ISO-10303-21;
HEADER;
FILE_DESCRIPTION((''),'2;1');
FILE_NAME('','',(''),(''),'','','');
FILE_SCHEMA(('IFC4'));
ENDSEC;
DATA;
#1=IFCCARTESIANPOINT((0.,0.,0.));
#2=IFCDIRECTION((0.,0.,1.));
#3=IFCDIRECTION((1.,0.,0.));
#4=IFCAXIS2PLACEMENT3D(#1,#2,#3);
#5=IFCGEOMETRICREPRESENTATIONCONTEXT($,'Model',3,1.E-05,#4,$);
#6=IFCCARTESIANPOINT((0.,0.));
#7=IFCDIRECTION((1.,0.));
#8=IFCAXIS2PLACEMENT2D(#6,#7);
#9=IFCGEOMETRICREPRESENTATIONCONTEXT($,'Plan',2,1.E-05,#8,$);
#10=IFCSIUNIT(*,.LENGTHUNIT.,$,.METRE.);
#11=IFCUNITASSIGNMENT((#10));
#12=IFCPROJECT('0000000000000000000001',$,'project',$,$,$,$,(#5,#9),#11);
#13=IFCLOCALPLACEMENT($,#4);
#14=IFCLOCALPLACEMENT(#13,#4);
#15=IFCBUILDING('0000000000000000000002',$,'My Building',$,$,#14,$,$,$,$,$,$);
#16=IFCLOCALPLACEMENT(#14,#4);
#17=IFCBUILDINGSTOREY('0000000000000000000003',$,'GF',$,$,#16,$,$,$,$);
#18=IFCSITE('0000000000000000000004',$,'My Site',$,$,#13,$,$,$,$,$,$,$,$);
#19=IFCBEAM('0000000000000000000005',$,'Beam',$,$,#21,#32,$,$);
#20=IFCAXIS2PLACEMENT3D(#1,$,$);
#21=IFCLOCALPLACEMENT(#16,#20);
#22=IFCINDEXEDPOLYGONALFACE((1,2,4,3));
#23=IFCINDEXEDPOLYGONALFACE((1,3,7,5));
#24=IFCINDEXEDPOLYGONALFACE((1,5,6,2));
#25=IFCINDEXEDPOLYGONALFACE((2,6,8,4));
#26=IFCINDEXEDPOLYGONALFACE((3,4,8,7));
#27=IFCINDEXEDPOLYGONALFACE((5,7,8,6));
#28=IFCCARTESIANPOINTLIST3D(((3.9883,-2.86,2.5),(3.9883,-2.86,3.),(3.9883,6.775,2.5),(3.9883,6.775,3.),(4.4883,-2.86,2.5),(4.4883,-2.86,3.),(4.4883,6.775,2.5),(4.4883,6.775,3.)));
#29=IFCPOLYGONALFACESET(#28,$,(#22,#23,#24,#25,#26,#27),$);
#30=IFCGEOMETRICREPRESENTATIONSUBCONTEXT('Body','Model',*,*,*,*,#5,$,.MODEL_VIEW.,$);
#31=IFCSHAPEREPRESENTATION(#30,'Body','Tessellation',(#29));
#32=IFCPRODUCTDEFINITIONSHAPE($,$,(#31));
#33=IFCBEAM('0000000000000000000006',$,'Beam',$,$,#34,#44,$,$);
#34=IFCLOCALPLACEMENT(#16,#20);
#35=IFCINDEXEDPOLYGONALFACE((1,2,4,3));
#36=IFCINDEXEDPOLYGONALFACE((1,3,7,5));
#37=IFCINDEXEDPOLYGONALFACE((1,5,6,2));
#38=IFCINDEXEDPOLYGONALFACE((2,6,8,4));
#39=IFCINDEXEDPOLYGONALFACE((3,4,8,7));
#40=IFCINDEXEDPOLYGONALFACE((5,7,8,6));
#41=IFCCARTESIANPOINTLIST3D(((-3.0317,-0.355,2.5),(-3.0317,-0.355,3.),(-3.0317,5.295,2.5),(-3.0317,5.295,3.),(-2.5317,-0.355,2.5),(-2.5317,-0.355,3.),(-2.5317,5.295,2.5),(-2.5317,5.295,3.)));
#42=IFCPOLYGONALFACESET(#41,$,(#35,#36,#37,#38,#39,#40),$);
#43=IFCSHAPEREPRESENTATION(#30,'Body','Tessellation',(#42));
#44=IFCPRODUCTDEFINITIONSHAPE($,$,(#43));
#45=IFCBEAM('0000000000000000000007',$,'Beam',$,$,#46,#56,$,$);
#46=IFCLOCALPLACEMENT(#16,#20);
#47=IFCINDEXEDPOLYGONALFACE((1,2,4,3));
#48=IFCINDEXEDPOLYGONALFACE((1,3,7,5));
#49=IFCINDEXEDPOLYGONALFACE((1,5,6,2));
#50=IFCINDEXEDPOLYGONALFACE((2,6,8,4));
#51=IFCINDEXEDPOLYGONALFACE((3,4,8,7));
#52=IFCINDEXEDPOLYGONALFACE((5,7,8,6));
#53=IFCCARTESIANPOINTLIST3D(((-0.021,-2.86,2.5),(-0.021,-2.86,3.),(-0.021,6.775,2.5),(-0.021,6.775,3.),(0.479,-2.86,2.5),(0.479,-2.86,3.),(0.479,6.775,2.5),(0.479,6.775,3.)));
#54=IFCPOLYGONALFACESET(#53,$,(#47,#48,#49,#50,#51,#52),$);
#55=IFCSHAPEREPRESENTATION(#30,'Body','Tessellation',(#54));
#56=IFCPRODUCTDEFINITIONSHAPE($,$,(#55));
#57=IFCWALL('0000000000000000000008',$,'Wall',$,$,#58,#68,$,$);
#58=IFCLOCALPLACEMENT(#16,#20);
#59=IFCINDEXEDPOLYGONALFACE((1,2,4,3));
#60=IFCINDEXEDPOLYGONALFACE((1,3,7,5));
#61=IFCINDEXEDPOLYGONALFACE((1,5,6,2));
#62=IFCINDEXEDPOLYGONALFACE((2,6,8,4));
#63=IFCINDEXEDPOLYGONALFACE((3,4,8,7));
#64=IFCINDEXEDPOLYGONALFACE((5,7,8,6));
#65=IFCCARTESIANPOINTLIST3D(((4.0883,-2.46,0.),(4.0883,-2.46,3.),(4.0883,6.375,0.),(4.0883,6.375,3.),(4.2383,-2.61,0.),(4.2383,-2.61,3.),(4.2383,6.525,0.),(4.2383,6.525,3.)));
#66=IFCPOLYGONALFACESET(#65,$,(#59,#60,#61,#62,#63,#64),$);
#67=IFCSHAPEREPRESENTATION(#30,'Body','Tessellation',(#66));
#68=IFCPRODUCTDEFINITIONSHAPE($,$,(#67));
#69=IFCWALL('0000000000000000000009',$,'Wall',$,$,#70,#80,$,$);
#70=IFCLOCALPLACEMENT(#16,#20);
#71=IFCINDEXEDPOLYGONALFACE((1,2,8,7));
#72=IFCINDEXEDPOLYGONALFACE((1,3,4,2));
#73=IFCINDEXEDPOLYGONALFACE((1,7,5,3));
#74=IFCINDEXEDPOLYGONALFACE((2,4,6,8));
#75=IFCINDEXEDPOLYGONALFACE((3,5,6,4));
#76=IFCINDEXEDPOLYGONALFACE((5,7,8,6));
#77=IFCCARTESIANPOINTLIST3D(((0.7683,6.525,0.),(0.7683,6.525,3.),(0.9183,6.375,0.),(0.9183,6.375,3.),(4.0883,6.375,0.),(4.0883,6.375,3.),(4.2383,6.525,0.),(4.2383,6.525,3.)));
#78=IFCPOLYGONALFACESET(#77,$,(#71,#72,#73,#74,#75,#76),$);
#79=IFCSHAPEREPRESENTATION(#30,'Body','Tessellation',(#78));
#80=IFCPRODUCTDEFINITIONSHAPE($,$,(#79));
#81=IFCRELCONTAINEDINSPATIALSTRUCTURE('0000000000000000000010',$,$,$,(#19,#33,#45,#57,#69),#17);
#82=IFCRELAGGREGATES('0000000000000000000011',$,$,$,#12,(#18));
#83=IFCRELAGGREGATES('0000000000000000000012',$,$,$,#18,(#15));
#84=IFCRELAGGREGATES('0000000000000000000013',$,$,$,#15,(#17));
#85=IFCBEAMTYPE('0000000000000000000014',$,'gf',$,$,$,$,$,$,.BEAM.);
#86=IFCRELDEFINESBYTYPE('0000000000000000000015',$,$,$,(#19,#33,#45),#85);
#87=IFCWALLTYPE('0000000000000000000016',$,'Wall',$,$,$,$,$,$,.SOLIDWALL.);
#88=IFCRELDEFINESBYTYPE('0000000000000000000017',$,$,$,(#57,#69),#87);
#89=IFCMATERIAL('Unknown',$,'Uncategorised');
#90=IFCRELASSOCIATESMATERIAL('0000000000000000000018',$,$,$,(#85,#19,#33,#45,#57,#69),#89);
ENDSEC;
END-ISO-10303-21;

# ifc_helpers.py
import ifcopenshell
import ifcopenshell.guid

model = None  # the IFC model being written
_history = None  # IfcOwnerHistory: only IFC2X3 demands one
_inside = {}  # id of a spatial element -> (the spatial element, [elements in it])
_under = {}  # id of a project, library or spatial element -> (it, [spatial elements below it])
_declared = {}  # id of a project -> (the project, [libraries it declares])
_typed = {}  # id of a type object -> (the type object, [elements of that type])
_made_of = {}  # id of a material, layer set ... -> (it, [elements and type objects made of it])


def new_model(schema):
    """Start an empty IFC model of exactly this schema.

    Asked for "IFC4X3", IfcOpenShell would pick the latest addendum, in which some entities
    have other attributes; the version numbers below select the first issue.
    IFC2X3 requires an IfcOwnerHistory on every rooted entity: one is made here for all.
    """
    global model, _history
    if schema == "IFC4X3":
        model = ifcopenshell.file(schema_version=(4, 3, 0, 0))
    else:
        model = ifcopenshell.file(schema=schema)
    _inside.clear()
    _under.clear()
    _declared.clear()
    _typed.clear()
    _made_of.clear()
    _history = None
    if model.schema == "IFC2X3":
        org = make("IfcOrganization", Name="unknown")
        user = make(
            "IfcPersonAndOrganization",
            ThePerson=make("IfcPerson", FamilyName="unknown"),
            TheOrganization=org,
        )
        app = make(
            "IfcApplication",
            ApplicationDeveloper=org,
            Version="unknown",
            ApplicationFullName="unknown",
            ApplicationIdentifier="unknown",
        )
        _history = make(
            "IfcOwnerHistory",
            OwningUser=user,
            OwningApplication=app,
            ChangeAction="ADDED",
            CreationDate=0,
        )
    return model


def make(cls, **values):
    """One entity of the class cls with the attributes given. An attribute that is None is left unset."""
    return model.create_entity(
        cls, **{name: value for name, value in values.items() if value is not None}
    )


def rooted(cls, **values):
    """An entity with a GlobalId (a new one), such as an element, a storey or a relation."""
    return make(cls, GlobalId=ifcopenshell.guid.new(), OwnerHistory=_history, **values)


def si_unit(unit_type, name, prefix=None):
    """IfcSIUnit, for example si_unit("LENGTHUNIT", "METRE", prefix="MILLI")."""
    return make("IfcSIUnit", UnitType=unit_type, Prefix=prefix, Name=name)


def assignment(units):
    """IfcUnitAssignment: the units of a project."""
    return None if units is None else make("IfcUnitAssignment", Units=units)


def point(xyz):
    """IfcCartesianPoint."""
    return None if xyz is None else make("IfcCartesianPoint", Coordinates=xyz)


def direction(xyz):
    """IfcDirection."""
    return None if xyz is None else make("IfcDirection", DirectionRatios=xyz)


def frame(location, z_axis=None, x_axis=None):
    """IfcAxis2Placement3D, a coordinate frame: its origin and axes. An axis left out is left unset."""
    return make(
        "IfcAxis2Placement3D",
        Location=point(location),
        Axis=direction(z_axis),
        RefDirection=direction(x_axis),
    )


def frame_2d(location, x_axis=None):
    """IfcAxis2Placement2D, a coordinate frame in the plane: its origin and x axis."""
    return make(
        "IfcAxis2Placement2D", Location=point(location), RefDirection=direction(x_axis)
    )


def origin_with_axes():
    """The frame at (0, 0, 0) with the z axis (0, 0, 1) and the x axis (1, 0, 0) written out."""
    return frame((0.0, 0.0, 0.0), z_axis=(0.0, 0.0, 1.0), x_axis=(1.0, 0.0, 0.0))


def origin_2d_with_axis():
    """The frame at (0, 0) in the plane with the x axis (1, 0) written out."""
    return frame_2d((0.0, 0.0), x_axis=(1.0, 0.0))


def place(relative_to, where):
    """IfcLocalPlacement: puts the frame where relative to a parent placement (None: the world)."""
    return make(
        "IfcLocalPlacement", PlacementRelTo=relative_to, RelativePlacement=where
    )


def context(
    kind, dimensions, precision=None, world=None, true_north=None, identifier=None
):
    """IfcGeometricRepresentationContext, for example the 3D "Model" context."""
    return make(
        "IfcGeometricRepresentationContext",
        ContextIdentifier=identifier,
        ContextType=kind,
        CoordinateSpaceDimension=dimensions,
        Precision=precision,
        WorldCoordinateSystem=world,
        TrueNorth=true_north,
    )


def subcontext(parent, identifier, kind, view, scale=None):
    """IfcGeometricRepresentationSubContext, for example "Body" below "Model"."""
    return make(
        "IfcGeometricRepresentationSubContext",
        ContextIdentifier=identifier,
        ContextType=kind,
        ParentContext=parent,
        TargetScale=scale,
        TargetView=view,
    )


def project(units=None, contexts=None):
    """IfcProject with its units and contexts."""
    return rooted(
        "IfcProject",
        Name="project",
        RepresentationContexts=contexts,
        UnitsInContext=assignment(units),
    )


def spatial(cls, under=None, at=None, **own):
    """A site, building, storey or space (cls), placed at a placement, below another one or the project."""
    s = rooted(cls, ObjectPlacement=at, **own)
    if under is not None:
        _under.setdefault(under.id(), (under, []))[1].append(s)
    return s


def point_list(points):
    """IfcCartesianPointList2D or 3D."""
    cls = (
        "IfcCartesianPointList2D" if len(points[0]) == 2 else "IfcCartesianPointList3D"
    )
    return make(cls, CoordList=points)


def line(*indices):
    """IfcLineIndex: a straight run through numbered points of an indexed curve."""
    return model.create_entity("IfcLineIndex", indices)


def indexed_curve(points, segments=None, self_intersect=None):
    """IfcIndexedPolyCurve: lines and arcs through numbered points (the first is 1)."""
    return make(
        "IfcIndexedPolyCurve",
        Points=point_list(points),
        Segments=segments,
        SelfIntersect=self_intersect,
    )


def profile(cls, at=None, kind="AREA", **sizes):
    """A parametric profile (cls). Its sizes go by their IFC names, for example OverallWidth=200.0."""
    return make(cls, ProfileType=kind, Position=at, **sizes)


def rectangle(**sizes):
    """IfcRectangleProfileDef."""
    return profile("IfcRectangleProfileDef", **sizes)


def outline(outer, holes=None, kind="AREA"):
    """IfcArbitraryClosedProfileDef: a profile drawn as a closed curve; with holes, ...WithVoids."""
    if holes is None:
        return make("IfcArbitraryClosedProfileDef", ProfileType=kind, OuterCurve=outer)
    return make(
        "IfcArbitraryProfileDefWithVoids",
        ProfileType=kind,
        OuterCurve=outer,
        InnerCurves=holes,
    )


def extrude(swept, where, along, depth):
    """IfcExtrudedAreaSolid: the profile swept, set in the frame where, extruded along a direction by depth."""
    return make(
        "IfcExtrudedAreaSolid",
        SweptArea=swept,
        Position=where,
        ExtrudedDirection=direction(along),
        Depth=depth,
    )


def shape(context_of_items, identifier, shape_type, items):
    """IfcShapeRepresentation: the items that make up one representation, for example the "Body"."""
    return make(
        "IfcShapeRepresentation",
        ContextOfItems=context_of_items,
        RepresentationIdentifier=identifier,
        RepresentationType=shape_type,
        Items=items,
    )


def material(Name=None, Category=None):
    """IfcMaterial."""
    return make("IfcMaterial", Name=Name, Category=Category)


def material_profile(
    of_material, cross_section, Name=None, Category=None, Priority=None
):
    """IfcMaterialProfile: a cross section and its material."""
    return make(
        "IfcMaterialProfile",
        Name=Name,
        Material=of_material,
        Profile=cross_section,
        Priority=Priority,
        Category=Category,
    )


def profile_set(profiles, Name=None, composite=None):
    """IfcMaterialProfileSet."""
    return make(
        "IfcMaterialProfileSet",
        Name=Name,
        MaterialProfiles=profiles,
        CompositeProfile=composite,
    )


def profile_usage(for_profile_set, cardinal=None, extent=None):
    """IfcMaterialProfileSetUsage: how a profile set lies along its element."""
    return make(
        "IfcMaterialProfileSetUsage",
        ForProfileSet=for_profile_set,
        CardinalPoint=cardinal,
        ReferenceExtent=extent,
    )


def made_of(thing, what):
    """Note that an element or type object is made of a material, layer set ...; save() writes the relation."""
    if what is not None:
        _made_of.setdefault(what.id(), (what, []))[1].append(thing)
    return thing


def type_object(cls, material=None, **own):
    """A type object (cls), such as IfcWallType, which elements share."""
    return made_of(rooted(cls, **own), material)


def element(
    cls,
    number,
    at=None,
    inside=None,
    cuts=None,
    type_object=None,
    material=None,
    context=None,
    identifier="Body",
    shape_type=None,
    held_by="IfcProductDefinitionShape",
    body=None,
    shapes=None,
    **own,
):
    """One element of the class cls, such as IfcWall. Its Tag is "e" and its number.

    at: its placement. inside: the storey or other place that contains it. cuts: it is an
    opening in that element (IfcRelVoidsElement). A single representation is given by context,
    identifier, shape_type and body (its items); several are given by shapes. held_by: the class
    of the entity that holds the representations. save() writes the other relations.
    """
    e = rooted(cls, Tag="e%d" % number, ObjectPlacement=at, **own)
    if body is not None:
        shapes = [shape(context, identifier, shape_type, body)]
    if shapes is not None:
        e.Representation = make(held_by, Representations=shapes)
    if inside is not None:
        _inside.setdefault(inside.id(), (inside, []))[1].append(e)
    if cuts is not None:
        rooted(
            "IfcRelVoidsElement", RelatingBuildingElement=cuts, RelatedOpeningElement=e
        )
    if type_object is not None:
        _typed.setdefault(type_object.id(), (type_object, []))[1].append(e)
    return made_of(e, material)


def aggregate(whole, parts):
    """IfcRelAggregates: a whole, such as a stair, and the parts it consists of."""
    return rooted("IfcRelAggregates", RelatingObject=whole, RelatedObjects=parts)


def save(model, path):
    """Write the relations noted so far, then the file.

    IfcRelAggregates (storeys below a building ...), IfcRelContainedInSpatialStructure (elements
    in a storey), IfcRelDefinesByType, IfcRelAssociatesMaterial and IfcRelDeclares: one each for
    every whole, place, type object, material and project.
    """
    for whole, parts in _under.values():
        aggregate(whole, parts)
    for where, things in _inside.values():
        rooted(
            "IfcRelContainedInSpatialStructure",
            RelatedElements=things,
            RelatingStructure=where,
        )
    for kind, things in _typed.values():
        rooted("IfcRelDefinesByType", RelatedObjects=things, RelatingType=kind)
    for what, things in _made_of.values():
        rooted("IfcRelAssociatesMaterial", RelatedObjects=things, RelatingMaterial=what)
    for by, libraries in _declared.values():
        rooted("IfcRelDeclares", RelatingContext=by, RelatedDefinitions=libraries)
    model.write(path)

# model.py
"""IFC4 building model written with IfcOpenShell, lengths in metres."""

from ifc_helpers import new_model, si_unit, frame, origin_with_axes, origin_2d_with_axis, place, context, subcontext, project, spatial, line, indexed_curve, rectangle, outline, extrude, material, material_profile, profile_set, profile_usage, type_object, element, save


model = new_model("IFC4")

# Units and contexts
model_context = context("Model", 3, precision=1e-05, world=origin_with_axes())
plan_context = context("Plan", 2, precision=1e-05, world=origin_2d_with_axis())
body_context_1 = subcontext(model_context, "Body", "Model", "MODEL_VIEW")
ifc_project = project(units=[si_unit("LENGTHUNIT", "METRE")], contexts=[model_context, plan_context])

# Site, building, storey
site_placement = place(None, origin_with_axes())
site = spatial("IfcSite", under=ifc_project, at=site_placement, Name="My Site")
building_placement = place(site_placement, origin_with_axes())
building = spatial("IfcBuilding", under=site, at=building_placement, Name="My Building")
storey_placement = place(building_placement, origin_with_axes())
storey = spatial("IfcBuildingStorey", under=building, at=storey_placement, Name="GF")

# Beams
ifc_material = material(Name="Unknown", Category="Uncategorised")
ifc_material_profile = material_profile(ifc_material, rectangle(XDim=0.5, YDim=0.5))
ifc_profile_set = profile_set([ifc_material_profile])
ifc_profile_usage_1 = profile_usage(ifc_profile_set, cardinal=7)
beam_type = type_object("IfcBeamType", Name="gf", PredefinedType="BEAM", material=ifc_profile_set)
beam_1_placement = place(storey_placement, frame((4.4883, 6.775, 3.0), z_axis=(0.0, -1.0, 0.0), x_axis=(1.0, 0.0, 0.0)))
element("IfcBeam", 1, at=beam_1_placement, inside=storey, type_object=beam_type, material=ifc_profile_usage_1, Name="Beam", context=body_context_1, shape_type="SweptSolid", body=[
    extrude(rectangle(XDim=0.5, YDim=0.5), frame((-0.25, -0.25, 0.0), z_axis=(0.0, 0.0, 1.0), x_axis=(1.0, 0.0, 0.0)), (0.0, 0.0, 1.0), 9.635),
])
ifc_profile_usage_2 = profile_usage(ifc_profile_set, cardinal=7)
beam_2_placement = place(storey_placement, frame((-2.5317, 5.295, 3.0), z_axis=(0.0, -1.0, 0.0), x_axis=(1.0, 0.0, 0.0)))
element("IfcBeam", 2, at=beam_2_placement, inside=storey, type_object=beam_type, material=ifc_profile_usage_2, Name="Beam", context=body_context_1, shape_type="SweptSolid", body=[
    extrude(rectangle(XDim=0.5, YDim=0.5), frame((-0.25, -0.25, 0.0), z_axis=(0.0, 0.0, 1.0), x_axis=(1.0, 0.0, 0.0)), (0.0, 0.0, 1.0), 5.65),
])
ifc_profile_usage_3 = profile_usage(ifc_profile_set, cardinal=7)
beam_3_placement = place(storey_placement, frame((0.479, 6.775, 3.0), z_axis=(0.0, -1.0, 0.0), x_axis=(1.0, 0.0, 0.0)))
element("IfcBeam", 3, at=beam_3_placement, inside=storey, type_object=beam_type, material=ifc_profile_usage_3, Name="Beam", context=body_context_1, shape_type="SweptSolid", body=[
    extrude(rectangle(XDim=0.5, YDim=0.5), frame((-0.25, -0.25, 0.0), z_axis=(0.0, 0.0, 1.0), x_axis=(1.0, 0.0, 0.0)), (0.0, 0.0, 1.0), 9.635),
])

# Shared definitions
wall_type_1 = type_object("IfcWallType", Name="Wall", PredefinedType="SOLIDWALL")

# Walls
wall_1_placement = place(storey_placement, frame((4.2383, -2.61, 0.0), z_axis=(0.0, 0.0, 1.0), x_axis=(0.0, 1.0, 0.0)))
element("IfcWall", 4, at=wall_1_placement, inside=storey, type_object=wall_type_1, material=ifc_material, Name="Wall", context=body_context_1, shape_type="SweptSolid", body=[
    extrude(outline(indexed_curve([(0.0, 0.0), (0.15, 0.15), (8.985, 0.15), (9.135, 0.0)], segments=[line(1, 2, 3, 4, 1)])), origin_with_axes(), (0.0, 0.0, 1.0), 3.0),
])
wall_2_placement = place(storey_placement, frame((4.2383, 6.525, 0.0), z_axis=(0.0, 0.0, 1.0), x_axis=(-1.0, 0.0, 0.0)))
element("IfcWall", 5, at=wall_2_placement, inside=storey, type_object=wall_type_1, material=ifc_material, Name="Wall", context=body_context_1, shape_type="SweptSolid", body=[
    extrude(outline(indexed_curve([(0.0, 0.0), (0.15, 0.15), (3.32, 0.15), (3.47, 0.0)], segments=[line(1, 2, 3, 4, 1)])), origin_with_axes(), (0.0, 0.0, 1.0), 3.0),
])

save(model, "model.ifc")
